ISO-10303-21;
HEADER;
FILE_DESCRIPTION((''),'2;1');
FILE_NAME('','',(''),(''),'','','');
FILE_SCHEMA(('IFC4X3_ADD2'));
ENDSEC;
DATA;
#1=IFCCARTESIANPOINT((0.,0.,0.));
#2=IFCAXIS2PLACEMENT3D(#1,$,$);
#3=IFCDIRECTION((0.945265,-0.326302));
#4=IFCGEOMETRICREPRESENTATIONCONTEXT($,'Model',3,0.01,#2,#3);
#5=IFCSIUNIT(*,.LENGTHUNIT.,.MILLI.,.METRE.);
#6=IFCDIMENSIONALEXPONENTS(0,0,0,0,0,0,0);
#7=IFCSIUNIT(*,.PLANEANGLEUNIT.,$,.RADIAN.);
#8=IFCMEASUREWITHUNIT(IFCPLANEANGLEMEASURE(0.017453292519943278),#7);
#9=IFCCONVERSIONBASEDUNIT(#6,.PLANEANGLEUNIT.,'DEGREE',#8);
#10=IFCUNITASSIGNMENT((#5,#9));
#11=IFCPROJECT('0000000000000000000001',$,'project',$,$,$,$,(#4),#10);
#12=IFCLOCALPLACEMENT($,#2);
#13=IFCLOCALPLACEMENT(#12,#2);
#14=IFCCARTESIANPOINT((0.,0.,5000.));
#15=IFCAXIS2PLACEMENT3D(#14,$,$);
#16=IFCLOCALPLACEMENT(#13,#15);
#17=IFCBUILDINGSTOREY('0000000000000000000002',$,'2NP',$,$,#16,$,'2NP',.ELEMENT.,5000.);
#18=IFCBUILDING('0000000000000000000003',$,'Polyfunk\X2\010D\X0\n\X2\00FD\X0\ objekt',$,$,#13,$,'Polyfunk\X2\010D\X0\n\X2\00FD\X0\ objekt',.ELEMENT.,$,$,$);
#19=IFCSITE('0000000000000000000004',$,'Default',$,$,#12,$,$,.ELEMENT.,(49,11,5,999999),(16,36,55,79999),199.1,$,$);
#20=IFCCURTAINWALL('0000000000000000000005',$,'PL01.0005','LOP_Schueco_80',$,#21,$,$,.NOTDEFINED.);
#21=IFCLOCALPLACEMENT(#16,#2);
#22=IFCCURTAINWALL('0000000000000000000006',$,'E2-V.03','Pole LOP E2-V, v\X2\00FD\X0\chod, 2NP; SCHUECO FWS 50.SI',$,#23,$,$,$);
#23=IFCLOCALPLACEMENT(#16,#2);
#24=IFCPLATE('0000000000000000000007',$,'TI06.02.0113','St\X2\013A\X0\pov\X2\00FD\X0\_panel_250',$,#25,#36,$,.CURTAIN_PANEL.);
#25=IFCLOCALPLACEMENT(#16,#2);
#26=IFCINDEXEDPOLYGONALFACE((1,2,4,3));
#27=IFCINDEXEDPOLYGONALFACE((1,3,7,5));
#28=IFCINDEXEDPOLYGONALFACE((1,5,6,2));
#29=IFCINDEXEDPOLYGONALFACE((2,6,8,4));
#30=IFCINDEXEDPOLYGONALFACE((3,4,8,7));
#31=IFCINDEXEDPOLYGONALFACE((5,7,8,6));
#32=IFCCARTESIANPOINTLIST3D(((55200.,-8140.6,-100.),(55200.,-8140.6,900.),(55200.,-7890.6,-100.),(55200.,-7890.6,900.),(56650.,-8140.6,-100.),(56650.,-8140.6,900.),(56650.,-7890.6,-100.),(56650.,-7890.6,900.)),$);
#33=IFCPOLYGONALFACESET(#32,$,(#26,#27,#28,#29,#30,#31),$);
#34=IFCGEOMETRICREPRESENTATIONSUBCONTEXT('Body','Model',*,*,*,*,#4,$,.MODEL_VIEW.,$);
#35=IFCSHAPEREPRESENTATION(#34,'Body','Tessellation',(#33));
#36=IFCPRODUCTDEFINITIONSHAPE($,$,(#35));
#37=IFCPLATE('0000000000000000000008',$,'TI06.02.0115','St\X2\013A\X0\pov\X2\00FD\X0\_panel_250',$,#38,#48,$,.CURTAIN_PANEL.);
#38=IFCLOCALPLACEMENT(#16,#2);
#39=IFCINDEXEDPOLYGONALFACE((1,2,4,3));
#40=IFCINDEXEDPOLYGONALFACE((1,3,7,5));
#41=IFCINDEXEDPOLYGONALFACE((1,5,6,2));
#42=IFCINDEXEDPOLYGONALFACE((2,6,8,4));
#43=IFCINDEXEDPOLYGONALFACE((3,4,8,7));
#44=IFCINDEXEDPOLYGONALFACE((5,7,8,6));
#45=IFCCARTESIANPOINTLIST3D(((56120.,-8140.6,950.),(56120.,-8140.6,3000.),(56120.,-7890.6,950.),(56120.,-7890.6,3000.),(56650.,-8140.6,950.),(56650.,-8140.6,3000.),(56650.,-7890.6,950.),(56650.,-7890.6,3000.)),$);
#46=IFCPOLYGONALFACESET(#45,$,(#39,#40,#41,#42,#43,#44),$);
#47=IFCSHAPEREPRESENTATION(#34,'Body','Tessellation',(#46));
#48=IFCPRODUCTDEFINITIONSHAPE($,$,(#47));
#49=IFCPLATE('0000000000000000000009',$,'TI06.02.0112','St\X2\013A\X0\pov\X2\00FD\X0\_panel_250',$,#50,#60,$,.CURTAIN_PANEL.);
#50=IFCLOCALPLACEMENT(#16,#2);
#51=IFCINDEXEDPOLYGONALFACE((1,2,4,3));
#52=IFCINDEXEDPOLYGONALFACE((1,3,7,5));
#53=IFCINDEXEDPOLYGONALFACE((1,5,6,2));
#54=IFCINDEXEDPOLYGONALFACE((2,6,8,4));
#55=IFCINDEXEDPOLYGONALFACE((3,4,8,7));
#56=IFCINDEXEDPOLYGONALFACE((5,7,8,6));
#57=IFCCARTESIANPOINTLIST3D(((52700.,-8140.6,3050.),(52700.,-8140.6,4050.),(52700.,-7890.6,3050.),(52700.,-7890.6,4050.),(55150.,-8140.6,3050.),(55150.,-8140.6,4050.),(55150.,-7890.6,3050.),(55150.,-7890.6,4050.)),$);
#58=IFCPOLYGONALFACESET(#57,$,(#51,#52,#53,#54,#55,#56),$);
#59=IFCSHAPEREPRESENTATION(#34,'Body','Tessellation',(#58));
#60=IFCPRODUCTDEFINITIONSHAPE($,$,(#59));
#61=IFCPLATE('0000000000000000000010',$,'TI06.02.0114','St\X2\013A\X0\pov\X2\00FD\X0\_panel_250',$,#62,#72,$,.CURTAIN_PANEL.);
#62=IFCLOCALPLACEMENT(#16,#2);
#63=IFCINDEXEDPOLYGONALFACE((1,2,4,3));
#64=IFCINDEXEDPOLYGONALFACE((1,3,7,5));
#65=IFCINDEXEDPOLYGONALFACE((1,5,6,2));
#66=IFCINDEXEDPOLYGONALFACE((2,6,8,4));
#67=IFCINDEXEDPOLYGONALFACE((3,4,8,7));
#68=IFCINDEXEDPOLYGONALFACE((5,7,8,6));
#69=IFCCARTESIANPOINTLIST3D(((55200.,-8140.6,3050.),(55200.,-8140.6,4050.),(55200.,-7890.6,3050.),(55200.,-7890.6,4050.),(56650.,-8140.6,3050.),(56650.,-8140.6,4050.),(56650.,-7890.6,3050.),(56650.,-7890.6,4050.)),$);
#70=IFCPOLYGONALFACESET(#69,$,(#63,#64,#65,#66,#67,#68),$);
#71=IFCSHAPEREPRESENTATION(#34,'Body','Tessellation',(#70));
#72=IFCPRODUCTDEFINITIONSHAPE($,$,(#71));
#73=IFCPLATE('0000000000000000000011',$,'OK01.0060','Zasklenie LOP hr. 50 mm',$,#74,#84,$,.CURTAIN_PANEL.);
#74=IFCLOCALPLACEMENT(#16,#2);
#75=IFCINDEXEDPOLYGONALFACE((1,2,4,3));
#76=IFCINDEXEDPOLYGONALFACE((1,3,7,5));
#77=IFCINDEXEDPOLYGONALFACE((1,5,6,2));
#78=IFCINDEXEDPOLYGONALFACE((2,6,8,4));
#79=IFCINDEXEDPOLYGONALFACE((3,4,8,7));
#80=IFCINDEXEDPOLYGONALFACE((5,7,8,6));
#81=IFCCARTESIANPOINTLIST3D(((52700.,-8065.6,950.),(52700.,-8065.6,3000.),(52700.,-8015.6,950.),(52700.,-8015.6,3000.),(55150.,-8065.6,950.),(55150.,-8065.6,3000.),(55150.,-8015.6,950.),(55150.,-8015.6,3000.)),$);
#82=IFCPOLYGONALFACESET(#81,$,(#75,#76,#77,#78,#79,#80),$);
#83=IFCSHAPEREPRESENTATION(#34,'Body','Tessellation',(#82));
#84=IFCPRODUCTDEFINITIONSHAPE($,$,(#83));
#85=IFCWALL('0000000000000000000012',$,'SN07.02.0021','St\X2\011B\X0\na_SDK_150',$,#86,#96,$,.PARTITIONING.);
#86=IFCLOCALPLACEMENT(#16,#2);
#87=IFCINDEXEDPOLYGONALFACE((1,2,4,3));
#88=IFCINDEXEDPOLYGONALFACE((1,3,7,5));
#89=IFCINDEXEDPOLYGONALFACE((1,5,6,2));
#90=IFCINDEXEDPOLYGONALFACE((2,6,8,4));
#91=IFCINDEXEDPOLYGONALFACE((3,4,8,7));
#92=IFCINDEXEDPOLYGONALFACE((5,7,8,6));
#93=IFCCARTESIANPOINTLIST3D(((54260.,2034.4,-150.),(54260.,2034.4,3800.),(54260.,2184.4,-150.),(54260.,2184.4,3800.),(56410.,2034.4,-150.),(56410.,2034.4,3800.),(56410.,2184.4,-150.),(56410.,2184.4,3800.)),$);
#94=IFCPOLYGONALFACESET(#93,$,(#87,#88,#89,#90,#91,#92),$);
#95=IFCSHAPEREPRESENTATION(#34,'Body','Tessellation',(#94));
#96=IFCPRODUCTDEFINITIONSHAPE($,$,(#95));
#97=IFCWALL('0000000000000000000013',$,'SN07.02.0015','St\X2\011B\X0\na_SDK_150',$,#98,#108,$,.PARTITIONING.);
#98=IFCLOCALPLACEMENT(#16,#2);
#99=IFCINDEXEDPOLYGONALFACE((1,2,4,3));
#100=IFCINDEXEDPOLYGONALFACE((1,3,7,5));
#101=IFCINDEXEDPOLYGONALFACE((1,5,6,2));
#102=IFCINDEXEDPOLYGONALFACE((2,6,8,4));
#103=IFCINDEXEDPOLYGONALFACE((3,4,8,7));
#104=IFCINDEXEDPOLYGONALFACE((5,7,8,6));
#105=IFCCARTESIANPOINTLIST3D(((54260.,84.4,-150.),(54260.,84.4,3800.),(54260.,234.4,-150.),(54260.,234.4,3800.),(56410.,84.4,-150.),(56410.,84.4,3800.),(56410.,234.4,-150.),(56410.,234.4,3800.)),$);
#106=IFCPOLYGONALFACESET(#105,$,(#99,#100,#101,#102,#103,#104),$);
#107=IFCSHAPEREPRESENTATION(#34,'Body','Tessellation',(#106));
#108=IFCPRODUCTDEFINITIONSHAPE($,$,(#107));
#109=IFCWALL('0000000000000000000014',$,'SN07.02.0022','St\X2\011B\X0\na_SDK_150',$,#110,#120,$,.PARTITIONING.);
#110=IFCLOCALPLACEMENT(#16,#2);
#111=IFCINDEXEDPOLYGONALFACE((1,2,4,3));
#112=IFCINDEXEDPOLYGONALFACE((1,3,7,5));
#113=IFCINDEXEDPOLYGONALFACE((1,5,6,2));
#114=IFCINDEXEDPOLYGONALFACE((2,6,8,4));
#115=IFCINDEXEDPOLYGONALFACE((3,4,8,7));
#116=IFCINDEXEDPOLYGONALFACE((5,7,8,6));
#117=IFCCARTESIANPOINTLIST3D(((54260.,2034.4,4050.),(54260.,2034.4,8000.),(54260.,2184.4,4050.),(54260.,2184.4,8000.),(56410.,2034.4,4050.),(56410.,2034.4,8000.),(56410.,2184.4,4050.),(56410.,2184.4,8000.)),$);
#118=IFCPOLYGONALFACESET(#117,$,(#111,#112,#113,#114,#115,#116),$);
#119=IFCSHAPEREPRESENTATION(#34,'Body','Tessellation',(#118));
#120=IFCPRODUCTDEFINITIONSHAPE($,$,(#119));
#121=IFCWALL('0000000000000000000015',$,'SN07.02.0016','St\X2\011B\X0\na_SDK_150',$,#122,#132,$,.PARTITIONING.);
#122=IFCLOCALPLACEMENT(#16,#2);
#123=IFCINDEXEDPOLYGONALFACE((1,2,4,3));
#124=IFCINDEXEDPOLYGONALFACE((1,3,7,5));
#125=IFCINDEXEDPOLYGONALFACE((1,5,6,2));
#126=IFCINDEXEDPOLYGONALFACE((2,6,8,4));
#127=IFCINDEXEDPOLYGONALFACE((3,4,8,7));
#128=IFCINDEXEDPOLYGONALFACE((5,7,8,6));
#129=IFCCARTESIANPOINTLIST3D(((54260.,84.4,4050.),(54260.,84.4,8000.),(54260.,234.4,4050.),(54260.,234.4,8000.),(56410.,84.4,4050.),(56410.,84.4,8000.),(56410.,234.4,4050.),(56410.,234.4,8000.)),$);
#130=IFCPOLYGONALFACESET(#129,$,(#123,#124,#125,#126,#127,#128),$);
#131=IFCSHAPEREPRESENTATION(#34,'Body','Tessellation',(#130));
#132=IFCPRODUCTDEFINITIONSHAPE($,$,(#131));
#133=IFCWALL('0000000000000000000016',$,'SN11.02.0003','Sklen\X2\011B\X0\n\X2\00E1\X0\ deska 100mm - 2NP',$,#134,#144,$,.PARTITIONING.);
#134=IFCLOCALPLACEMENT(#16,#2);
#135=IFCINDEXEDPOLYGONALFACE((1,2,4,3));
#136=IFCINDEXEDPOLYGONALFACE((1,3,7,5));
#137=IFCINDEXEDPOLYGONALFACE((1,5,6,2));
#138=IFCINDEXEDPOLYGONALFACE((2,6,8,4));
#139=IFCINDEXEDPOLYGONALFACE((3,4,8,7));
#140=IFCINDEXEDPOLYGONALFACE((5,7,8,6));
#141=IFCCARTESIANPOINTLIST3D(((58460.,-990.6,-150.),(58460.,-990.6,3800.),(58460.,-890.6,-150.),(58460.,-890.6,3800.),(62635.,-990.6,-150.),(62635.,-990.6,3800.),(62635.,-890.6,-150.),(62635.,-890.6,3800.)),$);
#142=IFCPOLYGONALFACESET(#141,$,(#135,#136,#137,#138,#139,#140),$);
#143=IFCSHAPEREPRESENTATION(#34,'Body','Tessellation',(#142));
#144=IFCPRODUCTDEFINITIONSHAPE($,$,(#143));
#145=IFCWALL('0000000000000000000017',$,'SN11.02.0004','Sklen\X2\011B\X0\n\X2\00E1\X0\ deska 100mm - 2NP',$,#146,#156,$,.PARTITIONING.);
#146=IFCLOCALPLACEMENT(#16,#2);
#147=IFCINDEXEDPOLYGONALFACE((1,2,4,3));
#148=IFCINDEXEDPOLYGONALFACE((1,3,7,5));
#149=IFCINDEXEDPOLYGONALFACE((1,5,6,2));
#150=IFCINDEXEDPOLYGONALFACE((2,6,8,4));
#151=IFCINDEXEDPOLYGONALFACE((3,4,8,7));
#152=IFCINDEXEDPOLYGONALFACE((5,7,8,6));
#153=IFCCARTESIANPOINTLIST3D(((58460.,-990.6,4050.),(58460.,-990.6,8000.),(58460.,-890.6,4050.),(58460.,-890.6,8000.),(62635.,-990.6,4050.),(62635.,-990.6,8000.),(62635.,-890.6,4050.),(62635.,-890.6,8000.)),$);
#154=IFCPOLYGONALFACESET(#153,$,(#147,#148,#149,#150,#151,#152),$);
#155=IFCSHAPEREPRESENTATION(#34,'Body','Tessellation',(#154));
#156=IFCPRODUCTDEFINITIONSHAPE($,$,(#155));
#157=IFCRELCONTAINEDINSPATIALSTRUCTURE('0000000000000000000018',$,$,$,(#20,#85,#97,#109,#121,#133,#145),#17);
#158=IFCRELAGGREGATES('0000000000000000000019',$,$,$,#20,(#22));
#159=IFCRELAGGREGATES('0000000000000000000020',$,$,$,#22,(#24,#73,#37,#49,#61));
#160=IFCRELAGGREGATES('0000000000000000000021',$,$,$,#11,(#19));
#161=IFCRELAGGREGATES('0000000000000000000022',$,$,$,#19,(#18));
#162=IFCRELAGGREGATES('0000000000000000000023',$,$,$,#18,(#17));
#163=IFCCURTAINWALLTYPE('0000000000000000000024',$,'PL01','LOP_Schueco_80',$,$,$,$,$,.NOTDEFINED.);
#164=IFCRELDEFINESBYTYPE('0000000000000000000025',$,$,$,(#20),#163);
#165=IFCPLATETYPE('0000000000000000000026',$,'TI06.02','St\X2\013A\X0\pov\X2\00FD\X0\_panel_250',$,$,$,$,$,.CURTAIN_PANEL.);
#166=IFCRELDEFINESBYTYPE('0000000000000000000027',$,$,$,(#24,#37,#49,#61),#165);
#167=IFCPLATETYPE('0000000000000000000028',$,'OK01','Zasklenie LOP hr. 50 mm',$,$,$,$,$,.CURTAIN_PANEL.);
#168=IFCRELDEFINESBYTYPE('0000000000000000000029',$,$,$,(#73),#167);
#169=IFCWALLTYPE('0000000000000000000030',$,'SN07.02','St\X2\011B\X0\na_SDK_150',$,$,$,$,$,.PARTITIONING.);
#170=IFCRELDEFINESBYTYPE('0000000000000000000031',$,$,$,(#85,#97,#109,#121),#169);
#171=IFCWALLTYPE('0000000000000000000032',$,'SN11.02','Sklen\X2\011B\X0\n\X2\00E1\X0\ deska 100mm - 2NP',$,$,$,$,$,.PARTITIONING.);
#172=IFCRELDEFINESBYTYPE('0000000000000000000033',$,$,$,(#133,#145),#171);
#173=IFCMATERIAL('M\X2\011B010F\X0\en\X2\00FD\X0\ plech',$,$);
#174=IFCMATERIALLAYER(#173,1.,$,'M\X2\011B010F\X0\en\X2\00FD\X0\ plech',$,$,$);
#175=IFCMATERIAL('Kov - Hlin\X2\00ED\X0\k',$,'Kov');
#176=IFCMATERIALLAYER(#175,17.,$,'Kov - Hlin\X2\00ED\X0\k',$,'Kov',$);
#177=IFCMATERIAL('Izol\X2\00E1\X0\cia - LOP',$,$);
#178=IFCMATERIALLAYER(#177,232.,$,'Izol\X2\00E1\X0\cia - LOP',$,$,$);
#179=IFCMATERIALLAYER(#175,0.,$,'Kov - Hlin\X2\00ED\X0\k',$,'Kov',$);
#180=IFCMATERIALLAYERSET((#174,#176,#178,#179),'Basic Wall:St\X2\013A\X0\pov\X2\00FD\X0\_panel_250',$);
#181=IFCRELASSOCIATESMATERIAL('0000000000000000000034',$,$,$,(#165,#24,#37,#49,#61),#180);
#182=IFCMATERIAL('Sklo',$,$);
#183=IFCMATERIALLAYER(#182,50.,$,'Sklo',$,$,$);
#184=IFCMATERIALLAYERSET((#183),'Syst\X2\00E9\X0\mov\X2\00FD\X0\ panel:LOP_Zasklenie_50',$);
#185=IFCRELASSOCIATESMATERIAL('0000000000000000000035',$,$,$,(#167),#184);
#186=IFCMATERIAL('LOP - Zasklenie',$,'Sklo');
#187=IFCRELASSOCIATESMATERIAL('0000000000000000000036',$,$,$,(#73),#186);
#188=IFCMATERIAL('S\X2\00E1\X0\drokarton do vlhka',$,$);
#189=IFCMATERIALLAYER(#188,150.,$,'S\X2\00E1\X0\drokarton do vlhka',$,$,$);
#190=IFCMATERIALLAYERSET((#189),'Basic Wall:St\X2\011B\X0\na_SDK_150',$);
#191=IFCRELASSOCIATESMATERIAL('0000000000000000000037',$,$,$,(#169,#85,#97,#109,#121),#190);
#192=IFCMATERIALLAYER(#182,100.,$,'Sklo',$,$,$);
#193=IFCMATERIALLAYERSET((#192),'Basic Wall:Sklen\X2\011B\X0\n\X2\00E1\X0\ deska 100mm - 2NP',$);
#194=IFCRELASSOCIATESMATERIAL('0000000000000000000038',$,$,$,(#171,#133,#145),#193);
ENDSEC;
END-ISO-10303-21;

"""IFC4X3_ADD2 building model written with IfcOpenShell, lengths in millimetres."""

from ifc_helpers import new_model, entity, si_unit, converted_unit, direction, frame, frame_2d, origin, origin_2d_with_axis, place, context, subcontext, project, spatial, polyline, rectangle, extrude, clip, bounded_halfspace, source, transform, mapped, material, layer, layer_set, layer_usage, type_object, type_shapes, element, aggregate, save


model = new_model("IFC4X3_ADD2")

# Units and contexts
model_context = context("Model", 3, precision=0.01, world=origin(), true_north=direction((0.945265, -0.326302)))
body_context = subcontext(model_context, "Body", "Model", "MODEL_VIEW")
ifc_project = project(units=[si_unit("LENGTHUNIT", "METRE", prefix="MILLI"), converted_unit("PLANEANGLEUNIT", "DEGREE", entity("IfcPlaneAngleMeasure", 0.017453292519943278), si_unit("PLANEANGLEUNIT", "RADIAN"), dimensions=[0, 0, 0, 0, 0, 0, 0])], contexts=[model_context])

# Site, building, storey
site_placement = place(None, origin())
site = spatial("IfcSite", under=ifc_project, at=site_placement, Name="Default", CompositionType="ELEMENT", RefLatitude=(49, 11, 5, 999999), RefLongitude=(16, 36, 55, 79999), RefElevation=199.1)
building_placement = place(site_placement, origin())
building = spatial("IfcBuilding", under=site, at=building_placement, Name="Polyfunkčný objekt", LongName="Polyfunkčný objekt", CompositionType="ELEMENT")
storey_placement = place(building_placement, frame((0.0, 0.0, 5000.0)))
storey = spatial("IfcBuildingStorey", under=building, at=storey_placement, Name="2NP", LongName="2NP", CompositionType="ELEMENT", Elevation=5000.0)

# Curtain walls, plates
curtain_wall_type = type_object("IfcCurtainWallType", Name="PL01", Description="LOP_Schueco_80", PredefinedType="NOTDEFINED")
curtain_wall_1_placement = place(storey_placement, frame((0.0, 0.0, -5000.0)))
curtain_wall_1 = element("IfcCurtainWall", 1, at=curtain_wall_1_placement, inside=storey, type_object=curtain_wall_type, Name="PL01.0005", Description="LOP_Schueco_80", PredefinedType="NOTDEFINED")
curtain_wall_2 = element("IfcCurtainWall", 2, Name="E2-V.03", Description="Pole LOP E2-V, východ, 2NP; SCHUECO FWS 50.SI")
aggregate(curtain_wall_1, [curtain_wall_2])
ifc_material_1 = material(Name="Měďený plech")
ifc_layer_1 = layer(ifc_material_1, 1.0, Name="Měďený plech")
ifc_material_2 = material(Name="Kov - Hliník", Category="Kov")
ifc_layer_2 = layer(ifc_material_2, 17.0, Name="Kov - Hliník", Category="Kov")
ifc_material_3 = material(Name="Izolácia - LOP")
ifc_layer_3 = layer(ifc_material_3, 232.0, Name="Izolácia - LOP")
ifc_layer_4 = layer(ifc_material_2, 0.0, Name="Kov - Hliník", Category="Kov")
ifc_layer_set_1 = layer_set([ifc_layer_1, ifc_layer_2, ifc_layer_3, ifc_layer_4], Name="Basic Wall:Stĺpový_panel_250")
ifc_layer_usage_1 = layer_usage(ifc_layer_set_1, "AXIS2", "POSITIVE", -125.0)
plate_type_1 = type_object("IfcPlateType", Name="TI06.02", Description="Stĺpový_panel_250", PredefinedType="CURTAIN_PANEL", material=ifc_layer_set_1)
plate_1_placement = place(storey_placement, frame((55200.0, -8015.6, -100.0)))
plate_1 = element("IfcPlate", 3, at=plate_1_placement, type_object=plate_type_1, material=ifc_layer_usage_1, Name="TI06.02.0113", Description="Stĺpový_panel_250", PredefinedType="CURTAIN_PANEL", context=body_context, shape_type="SweptSolid", body=[
    extrude(rectangle(XDim=250.0, YDim=1450.0, at=frame_2d((0.0, 0.0), x_axis=(1.0, 0.0))), frame((725.0, 0.0, 0.0), z_axis=(0.0, 0.0, 1.0), x_axis=(0.0, 1.0, 0.0)), (0.0, 0.0, 1.0), 1000.0),
])
ifc_layer_usage_2 = layer_usage(ifc_layer_set_1, "AXIS2", "POSITIVE", -125.0)
plate_2_placement = place(storey_placement, frame((56120.0, -8015.6, 950.0)))
plate_2 = element("IfcPlate", 4, at=plate_2_placement, type_object=plate_type_1, material=ifc_layer_usage_2, Name="TI06.02.0115", Description="Stĺpový_panel_250", PredefinedType="CURTAIN_PANEL", context=body_context, shape_type="SweptSolid", body=[
    extrude(rectangle(XDim=250.0, YDim=530.0, at=origin_2d_with_axis()), frame((265.0, 0.0, 0.0), z_axis=(0.0, 0.0, 1.0), x_axis=(0.0, 1.0, 0.0)), (0.0, 0.0, 1.0), 2050.0),
])
ifc_layer_usage_3 = layer_usage(ifc_layer_set_1, "AXIS2", "POSITIVE", -125.0)
plate_3_placement = place(storey_placement, frame((52700.0, -8015.6, 3050.0)))
plate_3 = element("IfcPlate", 5, at=plate_3_placement, type_object=plate_type_1, material=ifc_layer_usage_3, Name="TI06.02.0112", Description="Stĺpový_panel_250", PredefinedType="CURTAIN_PANEL", context=body_context, shape_type="SweptSolid", body=[
    extrude(rectangle(XDim=250.0, YDim=2450.0, at=frame_2d((0.0, 0.0), x_axis=(1.0, 0.0))), frame((1225.0, 0.0, 0.0), z_axis=(0.0, 0.0, 1.0), x_axis=(0.0, 1.0, 0.0)), (0.0, 0.0, 1.0), 1000.0),
])
ifc_layer_usage_4 = layer_usage(ifc_layer_set_1, "AXIS2", "POSITIVE", -125.0)
plate_4_placement = place(storey_placement, frame((55200.0, -8015.6, 3050.0)))
plate_4 = element("IfcPlate", 6, at=plate_4_placement, type_object=plate_type_1, material=ifc_layer_usage_4, Name="TI06.02.0114", Description="Stĺpový_panel_250", PredefinedType="CURTAIN_PANEL", context=body_context, shape_type="SweptSolid", body=[
    extrude(rectangle(XDim=250.0, YDim=1450.0, at=frame_2d((0.0, 0.0), x_axis=(1.0, 0.0))), frame((725.0, 0.0, 0.0), z_axis=(0.0, 0.0, 1.0), x_axis=(0.0, 1.0, 0.0)), (0.0, 0.0, 1.0), 1000.0),
])
ifc_material_4 = material(Name="LOP - Zasklenie", Category="Sklo")
ifc_material_5 = material(Name="Sklo")
ifc_layer_5 = layer(ifc_material_5, 50.0, Name="Sklo")
ifc_layer_set_2 = layer_set([ifc_layer_5], Name="Systémový panel:LOP_Zasklenie_50")
plate_type_2 = type_object("IfcPlateType", Name="OK01", Description="Zasklenie LOP hr. 50 mm", PredefinedType="CURTAIN_PANEL", material=ifc_layer_set_2)
shared_shape_1 = source(origin(), body_context, "Body", "SweptSolid", [
    extrude(rectangle(XDim=50.0, YDim=2450.0, at=origin_2d_with_axis()), frame((0.0, -25.0, 0.0), z_axis=(0.0, 0.0, 1.0), x_axis=(0.0, 1.0, 0.0)), (0.0, 0.0, 1.0), 2050.0),
])
type_shapes(plate_type_2, [shared_shape_1])
plate_5_placement = place(curtain_wall_1_placement, frame((53925.0, -8015.6, 5950.0)))
plate_5 = element("IfcPlate", 7, at=plate_5_placement, type_object=plate_type_2, material=ifc_material_4, Name="OK01.0060", Description="Zasklenie LOP hr. 50 mm", PredefinedType="CURTAIN_PANEL", context=body_context, shape_type="MappedRepresentation", body=[
    mapped(shared_shape_1, transform((0.0, 0.0, 0.0), scale=1.0)),
])

# Walls
ifc_material_6 = material(Name="Sádrokarton do vlhka")
ifc_layer_6 = layer(ifc_material_6, 150.0, Name="Sádrokarton do vlhka")
ifc_layer_set_3 = layer_set([ifc_layer_6], Name="Basic Wall:Stěna_SDK_150")
wall_type_1 = type_object("IfcWallType", Name="SN07.02", Description="Stěna_SDK_150", PredefinedType="PARTITIONING", material=ifc_layer_set_3)
wall_1_placement = place(storey_placement, frame((56410.0, 2109.4, -150.0), z_axis=(0.0, 0.0, 1.0), x_axis=(-1.0, 0.0, 0.0)))
element("IfcWall", 8, at=wall_1_placement, inside=storey, type_object=wall_type_1, material=ifc_layer_set_3, Name="SN07.02.0021", Description="Stěna_SDK_150", PredefinedType="PARTITIONING", context=body_context, shape_type="Clipping", body=[
    clip(clip(extrude(rectangle(XDim=2150.0, YDim=150.0, at=frame_2d((1075.0, 0.0), x_axis=(-1.0, 0.0))), origin(), (0.0, 0.0, 1.0), 3950.0), bounded_halfspace(frame((2150.0, -75.0, 0.0)), True, frame((2150.0, -75.0, 0.0)), polyline([(0.0, 0.0), (0.0, 150.0), (-2150.0, 150.0), (-2150.0, 0.0), (0.0, 0.0)]))), bounded_halfspace(frame((0.0, -75.0, 3950.0), z_axis=(0.0, 0.0, -1.0), x_axis=(-1.0, 0.0, 0.0)), True, frame((0.0, -75.0, 3950.0)), polyline([(0.0, 0.0), (2150.0, 0.0), (2150.0, 150.0), (0.0, 150.0), (0.0, 0.0)]))),
])
wall_2_placement = place(storey_placement, frame((56410.0, 159.4, -150.0), z_axis=(0.0, 0.0, 1.0), x_axis=(-1.0, 0.0, 0.0)))
element("IfcWall", 9, at=wall_2_placement, inside=storey, type_object=wall_type_1, material=ifc_layer_set_3, Name="SN07.02.0015", Description="Stěna_SDK_150", PredefinedType="PARTITIONING", context=body_context, shape_type="Clipping", body=[
    clip(clip(extrude(rectangle(XDim=2150.0, YDim=150.0, at=frame_2d((1075.0, 0.0), x_axis=(-1.0, 0.0))), origin(), (0.0, 0.0, 1.0), 3950.0), bounded_halfspace(frame((2150.0, -75.0, 0.0)), True, frame((2150.0, -75.0, 0.0)), polyline([(0.0, 0.0), (0.0, 150.0), (-2150.0, 150.0), (-2150.0, 0.0), (0.0, 0.0)]))), bounded_halfspace(frame((0.0, -75.0, 3950.0), z_axis=(0.0, 0.0, -1.0), x_axis=(-1.0, 0.0, 0.0)), True, frame((0.0, -75.0, 3950.0)), polyline([(0.0, 0.0), (2150.0, 0.0), (2150.0, 150.0), (0.0, 150.0), (0.0, 0.0)]))),
])
wall_3_placement = place(storey_placement, frame((56410.0, 2109.4, 4050.0), z_axis=(0.0, 0.0, 1.0), x_axis=(-1.0, 0.0, 0.0)))
element("IfcWall", 10, at=wall_3_placement, inside=storey, type_object=wall_type_1, material=ifc_layer_set_3, Name="SN07.02.0022", Description="Stěna_SDK_150", PredefinedType="PARTITIONING", context=body_context, shape_type="Clipping", body=[
    clip(clip(extrude(rectangle(XDim=2150.0, YDim=150.0, at=frame_2d((1075.0, 0.0), x_axis=(-1.0, 0.0))), origin(), (0.0, 0.0, 1.0), 3950.0), bounded_halfspace(frame((2150.0, -75.0, 0.0)), True, frame((2150.0, -75.0, 0.0)), polyline([(0.0, 0.0), (0.0, 150.0), (-2150.0, 150.0), (-2150.0, 0.0), (0.0, 0.0)]))), bounded_halfspace(frame((0.0, -75.0, 3950.0), z_axis=(0.0, 0.0, -1.0), x_axis=(-1.0, 0.0, 0.0)), True, frame((0.0, -75.0, 3950.0)), polyline([(0.0, 0.0), (2150.0, 0.0), (2150.0, 150.0), (0.0, 150.0), (0.0, 0.0)]))),
])
wall_4_placement = place(storey_placement, frame((56410.0, 159.4, 4050.0), z_axis=(0.0, 0.0, 1.0), x_axis=(-1.0, 0.0, 0.0)))
element("IfcWall", 11, at=wall_4_placement, inside=storey, type_object=wall_type_1, material=ifc_layer_set_3, Name="SN07.02.0016", Description="Stěna_SDK_150", PredefinedType="PARTITIONING", context=body_context, shape_type="Clipping", body=[
    clip(clip(extrude(rectangle(XDim=2150.0, YDim=150.0, at=frame_2d((1075.0, 0.0), x_axis=(-1.0, 0.0))), origin(), (0.0, 0.0, 1.0), 3950.0), bounded_halfspace(frame((2150.0, -75.0, 0.0)), True, frame((2150.0, -75.0, 0.0)), polyline([(0.0, 0.0), (0.0, 150.0), (-2150.0, 150.0), (-2150.0, 0.0), (0.0, 0.0)]))), bounded_halfspace(frame((0.0, -75.0, 3950.0), z_axis=(0.0, 0.0, -1.0), x_axis=(-1.0, 0.0, 0.0)), True, frame((0.0, -75.0, 3950.0)), polyline([(0.0, 0.0), (2150.0, 0.0), (2150.0, 150.0), (0.0, 150.0), (0.0, 0.0)]))),
])
ifc_layer_7 = layer(ifc_material_5, 100.0, Name="Sklo")
ifc_layer_set_4 = layer_set([ifc_layer_7], Name="Basic Wall:Skleněná deska 100mm - 2NP")
wall_type_2 = type_object("IfcWallType", Name="SN11.02", Description="Skleněná deska 100mm - 2NP", PredefinedType="PARTITIONING", material=ifc_layer_set_4)
wall_5_placement = place(storey_placement, frame((58460.0, -940.6, -150.0)))
element("IfcWall", 12, at=wall_5_placement, inside=storey, type_object=wall_type_2, material=ifc_layer_set_4, Name="SN11.02.0003", Description="Skleněná deska 100mm - 2NP", PredefinedType="PARTITIONING", context=body_context, shape_type="Clipping", body=[
    clip(clip(extrude(rectangle(XDim=4175.0, YDim=100.0, at=frame_2d((2087.5, 0.0), x_axis=(-1.0, 0.0))), origin(), (0.0, 0.0, 1.0), 3950.0), bounded_halfspace(frame((4175.0, -50.0, 0.0), z_axis=(0.0, 0.0, 1.0), x_axis=(-1.0, 0.0, 0.0)), True, frame((4175.0, -50.0, 0.0)), polyline([(0.0, 0.0), (0.0, 100.0), (-4075.0, 100.0), (-4175.0, 100.0), (-4175.0, 0.0), (0.0, 0.0)]))), bounded_halfspace(frame((0.0, -50.0, 3950.0), z_axis=(0.0, 0.0, -1.0), x_axis=(1.0, 0.0, 0.0)), True, frame((0.0, -50.0, 3950.0)), polyline([(0.0, 0.0), (4175.0, 0.0), (4175.0, 100.0), (100.0, 100.0), (0.0, 100.0), (0.0, 0.0)]))),
])
wall_6_placement = place(storey_placement, frame((58460.0, -940.6, 4050.0)))
element("IfcWall", 13, at=wall_6_placement, inside=storey, type_object=wall_type_2, material=ifc_layer_set_4, Name="SN11.02.0004", Description="Skleněná deska 100mm - 2NP", PredefinedType="PARTITIONING", context=body_context, shape_type="Clipping", body=[
    clip(clip(extrude(rectangle(XDim=4175.0, YDim=100.0, at=frame_2d((2087.5, 0.0), x_axis=(-1.0, 0.0))), origin(), (0.0, 0.0, 1.0), 3950.0), bounded_halfspace(frame((4175.0, -50.0, 0.0), z_axis=(0.0, 0.0, 1.0), x_axis=(-1.0, 0.0, 0.0)), True, frame((4175.0, -50.0, 0.0)), polyline([(0.0, 0.0), (0.0, 100.0), (-4075.0, 100.0), (-4175.0, 100.0), (-4175.0, 0.0), (0.0, 0.0)]))), bounded_halfspace(frame((0.0, -50.0, 3950.0), z_axis=(0.0, 0.0, -1.0), x_axis=(1.0, 0.0, 0.0)), True, frame((0.0, -50.0, 3950.0)), polyline([(0.0, 0.0), (4175.0, 0.0), (4175.0, 100.0), (100.0, 100.0), (0.0, 100.0), (0.0, 0.0)]))),
])

aggregate(curtain_wall_2, [plate_1, plate_5, plate_2, plate_3, plate_4])

save(model, "model.ifc")
